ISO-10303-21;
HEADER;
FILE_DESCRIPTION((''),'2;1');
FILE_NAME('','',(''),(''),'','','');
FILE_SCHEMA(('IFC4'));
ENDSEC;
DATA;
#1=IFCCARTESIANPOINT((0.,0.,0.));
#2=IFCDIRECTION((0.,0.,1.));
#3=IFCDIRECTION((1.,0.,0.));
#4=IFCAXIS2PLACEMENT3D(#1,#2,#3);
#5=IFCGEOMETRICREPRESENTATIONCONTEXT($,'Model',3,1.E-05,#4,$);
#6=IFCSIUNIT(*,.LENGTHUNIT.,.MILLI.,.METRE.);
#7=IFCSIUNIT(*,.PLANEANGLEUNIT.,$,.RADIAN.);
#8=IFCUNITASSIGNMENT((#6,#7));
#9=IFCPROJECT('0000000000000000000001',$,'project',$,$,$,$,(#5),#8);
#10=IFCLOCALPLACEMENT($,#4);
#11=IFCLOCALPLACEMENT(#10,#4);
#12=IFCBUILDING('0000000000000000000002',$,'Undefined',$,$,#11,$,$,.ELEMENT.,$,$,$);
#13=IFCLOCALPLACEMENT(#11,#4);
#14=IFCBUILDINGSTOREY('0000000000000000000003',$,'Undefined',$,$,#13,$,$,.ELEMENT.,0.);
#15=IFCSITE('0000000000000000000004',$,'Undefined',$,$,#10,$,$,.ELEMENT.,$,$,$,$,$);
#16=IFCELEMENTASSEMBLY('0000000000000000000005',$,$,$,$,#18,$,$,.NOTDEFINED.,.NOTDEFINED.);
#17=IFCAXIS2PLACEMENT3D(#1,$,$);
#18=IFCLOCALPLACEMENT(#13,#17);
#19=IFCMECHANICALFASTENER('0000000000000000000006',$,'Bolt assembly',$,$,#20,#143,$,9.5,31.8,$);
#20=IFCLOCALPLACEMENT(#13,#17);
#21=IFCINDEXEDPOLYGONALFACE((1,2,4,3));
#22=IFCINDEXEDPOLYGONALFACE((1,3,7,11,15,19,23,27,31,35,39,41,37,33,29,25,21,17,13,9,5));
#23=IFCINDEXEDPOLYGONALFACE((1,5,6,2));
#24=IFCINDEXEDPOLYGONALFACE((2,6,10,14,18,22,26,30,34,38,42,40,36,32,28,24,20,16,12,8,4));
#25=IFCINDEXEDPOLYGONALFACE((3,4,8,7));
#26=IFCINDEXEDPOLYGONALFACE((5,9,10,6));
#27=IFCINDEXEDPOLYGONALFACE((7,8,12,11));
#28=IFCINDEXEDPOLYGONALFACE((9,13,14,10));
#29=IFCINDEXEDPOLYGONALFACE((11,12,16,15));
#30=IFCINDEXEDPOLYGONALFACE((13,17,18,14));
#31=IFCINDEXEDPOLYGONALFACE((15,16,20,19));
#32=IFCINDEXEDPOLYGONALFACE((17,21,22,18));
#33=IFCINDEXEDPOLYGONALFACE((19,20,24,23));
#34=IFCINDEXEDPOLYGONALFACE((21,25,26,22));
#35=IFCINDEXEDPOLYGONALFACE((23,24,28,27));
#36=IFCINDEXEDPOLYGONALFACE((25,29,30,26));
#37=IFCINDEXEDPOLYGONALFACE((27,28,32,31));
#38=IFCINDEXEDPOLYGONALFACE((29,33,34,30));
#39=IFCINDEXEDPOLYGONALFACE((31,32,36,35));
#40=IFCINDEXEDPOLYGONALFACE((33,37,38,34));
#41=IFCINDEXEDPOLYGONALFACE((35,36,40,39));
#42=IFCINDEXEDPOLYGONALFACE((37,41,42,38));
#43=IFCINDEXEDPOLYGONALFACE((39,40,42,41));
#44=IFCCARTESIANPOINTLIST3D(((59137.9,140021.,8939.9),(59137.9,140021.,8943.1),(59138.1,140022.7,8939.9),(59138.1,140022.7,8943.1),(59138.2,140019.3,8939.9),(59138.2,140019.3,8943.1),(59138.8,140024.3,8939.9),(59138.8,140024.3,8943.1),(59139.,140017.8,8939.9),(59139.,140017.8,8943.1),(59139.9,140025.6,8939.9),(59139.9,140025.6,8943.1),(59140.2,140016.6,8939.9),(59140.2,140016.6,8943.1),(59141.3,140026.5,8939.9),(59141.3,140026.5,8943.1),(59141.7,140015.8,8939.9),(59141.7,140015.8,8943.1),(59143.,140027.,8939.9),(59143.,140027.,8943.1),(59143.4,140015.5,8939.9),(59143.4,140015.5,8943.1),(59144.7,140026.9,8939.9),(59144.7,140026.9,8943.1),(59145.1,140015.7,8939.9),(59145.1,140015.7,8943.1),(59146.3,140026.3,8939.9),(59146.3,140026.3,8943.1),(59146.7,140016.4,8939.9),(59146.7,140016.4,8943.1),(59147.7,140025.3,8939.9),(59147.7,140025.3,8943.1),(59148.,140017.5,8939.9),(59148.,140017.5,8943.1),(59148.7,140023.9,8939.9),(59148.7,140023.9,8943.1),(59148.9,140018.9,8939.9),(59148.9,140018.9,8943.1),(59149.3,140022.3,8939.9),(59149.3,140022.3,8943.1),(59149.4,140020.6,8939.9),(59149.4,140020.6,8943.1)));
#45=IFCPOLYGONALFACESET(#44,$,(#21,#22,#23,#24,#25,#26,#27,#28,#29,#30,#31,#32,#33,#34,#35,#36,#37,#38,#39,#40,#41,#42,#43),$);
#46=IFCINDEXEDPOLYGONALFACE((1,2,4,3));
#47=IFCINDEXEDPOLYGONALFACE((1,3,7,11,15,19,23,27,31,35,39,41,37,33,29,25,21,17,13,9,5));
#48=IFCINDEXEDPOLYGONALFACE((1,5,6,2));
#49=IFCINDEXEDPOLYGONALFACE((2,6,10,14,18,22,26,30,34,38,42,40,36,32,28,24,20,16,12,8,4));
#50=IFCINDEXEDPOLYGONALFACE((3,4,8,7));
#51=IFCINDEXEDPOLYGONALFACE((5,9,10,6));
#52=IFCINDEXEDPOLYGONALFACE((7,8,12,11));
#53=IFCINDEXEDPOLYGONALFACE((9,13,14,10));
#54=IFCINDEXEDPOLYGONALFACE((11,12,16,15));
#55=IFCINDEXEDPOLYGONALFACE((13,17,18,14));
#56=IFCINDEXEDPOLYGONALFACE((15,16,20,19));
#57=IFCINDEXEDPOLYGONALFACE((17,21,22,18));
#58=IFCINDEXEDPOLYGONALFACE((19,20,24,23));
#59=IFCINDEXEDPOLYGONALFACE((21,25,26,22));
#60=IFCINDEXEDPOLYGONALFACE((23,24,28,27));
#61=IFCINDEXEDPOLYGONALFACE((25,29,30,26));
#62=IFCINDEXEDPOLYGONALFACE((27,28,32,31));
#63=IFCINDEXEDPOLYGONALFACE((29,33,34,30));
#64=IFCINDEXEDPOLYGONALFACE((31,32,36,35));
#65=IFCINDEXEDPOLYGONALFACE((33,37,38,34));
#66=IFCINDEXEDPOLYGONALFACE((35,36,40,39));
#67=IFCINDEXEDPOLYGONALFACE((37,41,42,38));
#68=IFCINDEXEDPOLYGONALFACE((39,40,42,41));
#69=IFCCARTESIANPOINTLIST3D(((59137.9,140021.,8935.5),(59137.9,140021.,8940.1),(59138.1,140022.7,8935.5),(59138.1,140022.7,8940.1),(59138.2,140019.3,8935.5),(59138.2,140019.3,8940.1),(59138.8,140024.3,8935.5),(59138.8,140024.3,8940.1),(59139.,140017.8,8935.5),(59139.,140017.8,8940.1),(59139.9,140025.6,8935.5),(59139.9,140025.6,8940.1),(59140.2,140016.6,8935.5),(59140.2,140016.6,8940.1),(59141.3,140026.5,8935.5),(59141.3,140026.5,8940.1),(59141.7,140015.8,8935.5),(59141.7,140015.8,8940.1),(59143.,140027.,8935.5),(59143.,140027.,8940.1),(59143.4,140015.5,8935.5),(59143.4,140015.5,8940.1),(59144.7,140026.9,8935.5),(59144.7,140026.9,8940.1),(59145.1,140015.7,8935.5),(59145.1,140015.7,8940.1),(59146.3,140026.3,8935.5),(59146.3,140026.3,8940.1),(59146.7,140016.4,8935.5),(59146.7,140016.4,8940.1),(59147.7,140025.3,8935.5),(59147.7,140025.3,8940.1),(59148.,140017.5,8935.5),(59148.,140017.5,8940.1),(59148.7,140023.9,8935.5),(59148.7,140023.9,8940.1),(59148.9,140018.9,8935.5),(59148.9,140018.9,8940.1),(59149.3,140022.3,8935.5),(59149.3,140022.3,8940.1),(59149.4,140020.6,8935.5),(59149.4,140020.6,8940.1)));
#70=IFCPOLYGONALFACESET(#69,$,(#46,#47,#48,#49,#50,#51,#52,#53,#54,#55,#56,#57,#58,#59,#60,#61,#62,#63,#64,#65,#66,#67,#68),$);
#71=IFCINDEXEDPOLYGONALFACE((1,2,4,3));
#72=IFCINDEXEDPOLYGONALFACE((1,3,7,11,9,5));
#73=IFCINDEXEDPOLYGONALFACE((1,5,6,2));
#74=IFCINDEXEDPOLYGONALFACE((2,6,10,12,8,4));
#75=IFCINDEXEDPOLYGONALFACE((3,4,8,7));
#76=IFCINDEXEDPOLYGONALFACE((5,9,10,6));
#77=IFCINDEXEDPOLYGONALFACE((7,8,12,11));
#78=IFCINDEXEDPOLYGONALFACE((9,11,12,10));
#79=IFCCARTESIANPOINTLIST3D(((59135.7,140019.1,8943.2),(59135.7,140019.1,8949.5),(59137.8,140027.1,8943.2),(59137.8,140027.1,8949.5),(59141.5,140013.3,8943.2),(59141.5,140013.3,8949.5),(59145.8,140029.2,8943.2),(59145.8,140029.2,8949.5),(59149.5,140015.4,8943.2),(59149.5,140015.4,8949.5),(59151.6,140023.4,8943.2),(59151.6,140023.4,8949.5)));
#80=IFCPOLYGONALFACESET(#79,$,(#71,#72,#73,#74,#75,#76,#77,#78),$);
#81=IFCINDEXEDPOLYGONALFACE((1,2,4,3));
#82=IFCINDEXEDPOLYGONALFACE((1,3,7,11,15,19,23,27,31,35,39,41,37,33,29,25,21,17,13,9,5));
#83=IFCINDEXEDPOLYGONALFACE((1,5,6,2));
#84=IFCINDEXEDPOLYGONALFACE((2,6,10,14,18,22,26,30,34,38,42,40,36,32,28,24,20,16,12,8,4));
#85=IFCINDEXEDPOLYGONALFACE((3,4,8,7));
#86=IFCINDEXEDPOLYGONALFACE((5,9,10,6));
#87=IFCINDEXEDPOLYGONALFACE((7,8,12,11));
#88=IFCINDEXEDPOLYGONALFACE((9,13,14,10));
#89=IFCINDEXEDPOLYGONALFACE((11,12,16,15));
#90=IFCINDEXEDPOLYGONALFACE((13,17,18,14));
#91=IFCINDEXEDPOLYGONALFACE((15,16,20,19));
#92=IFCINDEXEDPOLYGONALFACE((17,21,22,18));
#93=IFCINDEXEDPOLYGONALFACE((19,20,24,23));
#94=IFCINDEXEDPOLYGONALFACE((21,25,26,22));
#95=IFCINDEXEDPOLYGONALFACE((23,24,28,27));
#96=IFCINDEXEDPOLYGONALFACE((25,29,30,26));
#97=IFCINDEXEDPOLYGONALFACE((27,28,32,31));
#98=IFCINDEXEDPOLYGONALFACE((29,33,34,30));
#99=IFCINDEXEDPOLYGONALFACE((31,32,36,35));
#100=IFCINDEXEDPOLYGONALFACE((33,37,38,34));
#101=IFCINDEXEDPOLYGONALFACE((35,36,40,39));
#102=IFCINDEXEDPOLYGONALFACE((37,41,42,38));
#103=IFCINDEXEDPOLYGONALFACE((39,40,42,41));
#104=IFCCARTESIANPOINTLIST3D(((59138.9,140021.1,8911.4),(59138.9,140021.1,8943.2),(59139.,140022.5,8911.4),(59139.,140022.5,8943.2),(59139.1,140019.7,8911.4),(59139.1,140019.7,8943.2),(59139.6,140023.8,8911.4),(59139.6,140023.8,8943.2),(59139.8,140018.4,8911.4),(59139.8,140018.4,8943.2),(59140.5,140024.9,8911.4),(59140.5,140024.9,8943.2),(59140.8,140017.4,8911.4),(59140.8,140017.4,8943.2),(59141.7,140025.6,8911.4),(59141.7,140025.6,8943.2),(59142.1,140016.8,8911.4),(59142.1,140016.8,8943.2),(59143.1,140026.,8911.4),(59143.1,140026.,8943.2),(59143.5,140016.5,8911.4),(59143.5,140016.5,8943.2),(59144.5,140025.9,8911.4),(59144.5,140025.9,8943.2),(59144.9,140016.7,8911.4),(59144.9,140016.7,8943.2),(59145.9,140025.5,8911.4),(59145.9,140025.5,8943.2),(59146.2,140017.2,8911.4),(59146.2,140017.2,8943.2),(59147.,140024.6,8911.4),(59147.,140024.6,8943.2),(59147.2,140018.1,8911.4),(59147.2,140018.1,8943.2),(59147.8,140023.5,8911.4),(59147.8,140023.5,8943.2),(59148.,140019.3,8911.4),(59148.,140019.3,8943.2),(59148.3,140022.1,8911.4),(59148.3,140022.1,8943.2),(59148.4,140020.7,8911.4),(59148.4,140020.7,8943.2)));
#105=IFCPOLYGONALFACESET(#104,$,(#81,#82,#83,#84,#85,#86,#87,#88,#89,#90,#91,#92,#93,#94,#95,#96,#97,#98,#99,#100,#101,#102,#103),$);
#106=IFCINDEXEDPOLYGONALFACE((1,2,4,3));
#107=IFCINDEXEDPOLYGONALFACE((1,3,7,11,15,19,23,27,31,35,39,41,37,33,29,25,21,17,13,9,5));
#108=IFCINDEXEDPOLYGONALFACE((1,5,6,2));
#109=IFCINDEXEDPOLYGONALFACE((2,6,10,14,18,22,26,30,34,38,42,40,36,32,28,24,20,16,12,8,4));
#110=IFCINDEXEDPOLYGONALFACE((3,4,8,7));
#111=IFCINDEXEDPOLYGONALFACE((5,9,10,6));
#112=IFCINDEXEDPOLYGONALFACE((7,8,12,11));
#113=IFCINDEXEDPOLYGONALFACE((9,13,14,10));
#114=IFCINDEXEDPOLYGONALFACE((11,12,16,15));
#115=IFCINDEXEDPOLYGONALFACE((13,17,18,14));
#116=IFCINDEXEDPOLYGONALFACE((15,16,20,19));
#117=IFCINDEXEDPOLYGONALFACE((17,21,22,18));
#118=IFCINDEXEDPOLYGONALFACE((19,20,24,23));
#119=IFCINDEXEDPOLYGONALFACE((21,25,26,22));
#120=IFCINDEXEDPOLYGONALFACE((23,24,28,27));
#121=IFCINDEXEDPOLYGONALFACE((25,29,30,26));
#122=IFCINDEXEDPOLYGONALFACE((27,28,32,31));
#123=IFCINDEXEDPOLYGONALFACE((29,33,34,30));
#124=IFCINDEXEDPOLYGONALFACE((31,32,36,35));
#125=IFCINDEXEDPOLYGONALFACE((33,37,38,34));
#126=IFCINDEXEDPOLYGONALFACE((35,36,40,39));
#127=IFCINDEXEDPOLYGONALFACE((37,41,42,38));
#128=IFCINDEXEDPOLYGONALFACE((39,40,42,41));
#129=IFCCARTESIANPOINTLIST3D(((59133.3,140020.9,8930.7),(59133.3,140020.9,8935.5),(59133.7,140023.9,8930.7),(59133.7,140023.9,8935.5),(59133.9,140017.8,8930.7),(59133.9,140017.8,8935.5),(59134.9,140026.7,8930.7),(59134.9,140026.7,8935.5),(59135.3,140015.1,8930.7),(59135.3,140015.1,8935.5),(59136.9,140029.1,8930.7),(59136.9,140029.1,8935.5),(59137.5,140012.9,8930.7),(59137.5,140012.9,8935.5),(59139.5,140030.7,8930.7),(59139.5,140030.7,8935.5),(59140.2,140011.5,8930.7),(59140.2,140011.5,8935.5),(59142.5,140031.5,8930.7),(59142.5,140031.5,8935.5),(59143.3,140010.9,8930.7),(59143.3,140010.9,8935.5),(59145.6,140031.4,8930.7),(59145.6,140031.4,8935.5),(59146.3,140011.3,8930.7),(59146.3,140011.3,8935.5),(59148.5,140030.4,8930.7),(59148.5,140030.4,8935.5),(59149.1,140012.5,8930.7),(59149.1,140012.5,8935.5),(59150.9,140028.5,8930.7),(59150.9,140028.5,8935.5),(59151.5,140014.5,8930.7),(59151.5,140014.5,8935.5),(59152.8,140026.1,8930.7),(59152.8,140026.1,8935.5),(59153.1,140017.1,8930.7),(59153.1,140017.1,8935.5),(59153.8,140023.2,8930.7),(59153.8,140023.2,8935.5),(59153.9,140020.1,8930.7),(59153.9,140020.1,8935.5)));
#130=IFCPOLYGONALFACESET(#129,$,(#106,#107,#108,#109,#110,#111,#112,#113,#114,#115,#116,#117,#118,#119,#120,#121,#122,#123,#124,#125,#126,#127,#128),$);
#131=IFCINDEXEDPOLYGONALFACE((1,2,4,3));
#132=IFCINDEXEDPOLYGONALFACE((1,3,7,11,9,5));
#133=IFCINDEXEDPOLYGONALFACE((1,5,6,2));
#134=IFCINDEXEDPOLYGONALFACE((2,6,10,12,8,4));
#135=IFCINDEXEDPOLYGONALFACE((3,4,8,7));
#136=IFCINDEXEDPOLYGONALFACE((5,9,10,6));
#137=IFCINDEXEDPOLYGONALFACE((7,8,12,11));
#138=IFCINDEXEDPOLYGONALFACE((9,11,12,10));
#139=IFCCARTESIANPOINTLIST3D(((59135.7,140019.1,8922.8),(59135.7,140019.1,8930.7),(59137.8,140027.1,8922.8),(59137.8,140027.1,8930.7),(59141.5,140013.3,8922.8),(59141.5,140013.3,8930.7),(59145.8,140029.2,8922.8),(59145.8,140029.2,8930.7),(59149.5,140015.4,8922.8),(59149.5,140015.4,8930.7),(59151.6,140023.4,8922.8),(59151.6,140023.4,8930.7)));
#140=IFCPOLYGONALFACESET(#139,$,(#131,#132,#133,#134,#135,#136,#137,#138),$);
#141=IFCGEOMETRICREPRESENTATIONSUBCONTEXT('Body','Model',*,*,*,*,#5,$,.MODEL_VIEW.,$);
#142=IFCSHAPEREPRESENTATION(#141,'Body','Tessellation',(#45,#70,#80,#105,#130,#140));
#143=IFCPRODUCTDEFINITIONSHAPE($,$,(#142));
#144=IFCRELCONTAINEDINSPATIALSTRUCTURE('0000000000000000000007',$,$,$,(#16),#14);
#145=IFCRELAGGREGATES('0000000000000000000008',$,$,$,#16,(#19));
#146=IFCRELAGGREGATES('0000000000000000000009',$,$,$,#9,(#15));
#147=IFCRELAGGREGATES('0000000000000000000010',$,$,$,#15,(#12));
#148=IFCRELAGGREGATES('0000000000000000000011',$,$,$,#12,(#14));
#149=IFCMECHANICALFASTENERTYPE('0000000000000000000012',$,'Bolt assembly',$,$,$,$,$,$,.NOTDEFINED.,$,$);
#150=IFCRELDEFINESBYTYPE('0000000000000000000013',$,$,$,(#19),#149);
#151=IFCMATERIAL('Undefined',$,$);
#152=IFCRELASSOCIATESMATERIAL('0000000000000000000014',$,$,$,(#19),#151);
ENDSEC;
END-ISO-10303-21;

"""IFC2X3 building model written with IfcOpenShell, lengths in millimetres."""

from ifc_helpers import new_model, si_unit, frame, origin_with_axes, origin_2d_with_axis, place, context, subcontext, project, spatial, polyline, circle, outline, extrude, source, transform, mapped, material, type_object, element, aggregate, save


model = new_model("IFC2X3")

# Units and contexts
model_context = context("Model", 3, precision=1e-05, world=origin_with_axes())
body_context = subcontext(model_context, "Body", "Model", "MODEL_VIEW")
ifc_project = project(units=[si_unit("LENGTHUNIT", "METRE", prefix="MILLI"), si_unit("PLANEANGLEUNIT", "RADIAN")], contexts=[model_context])

# Site, building, storey
site_placement = place(None, origin_with_axes())
site = spatial("IfcSite", under=ifc_project, at=site_placement, Name="Undefined", CompositionType="ELEMENT")
building_placement = place(site_placement, origin_with_axes())
building = spatial("IfcBuilding", under=site, at=building_placement, Name="Undefined", CompositionType="ELEMENT")
storey_placement = place(building_placement, origin_with_axes())
storey = spatial("IfcBuildingStorey", under=building, at=storey_placement, Name="Undefined", CompositionType="ELEMENT", Elevation=0.0)

# Element assembly
assembly_1_placement = place(storey_placement, origin_with_axes())
assembly_1 = element("IfcElementAssembly", 1, at=assembly_1_placement, inside=storey, AssemblyPlace="NOTDEFINED", PredefinedType="NOTDEFINED")

# Mechanical fastener
ifc_material_1 = material(Name="Undefined")
mechanical_fastener_type = type_object("IfcMechanicalFastenerType", Name="Bolt assembly")
shared_shape_1 = source(origin_with_axes(), body_context, "Body", "SweptSolid", [
    extrude(circle(Radius=5.8, at=origin_2d_with_axis()), frame((0.0, -7.6, 0.0), z_axis=(0.0, 1.0, 0.0), x_axis=(1.0, 0.0, 0.0)), (0.0, 0.0, 1.0), 3.2),
    extrude(circle(Radius=5.8, at=origin_2d_with_axis()), frame((0.0, -4.6, 0.0), z_axis=(0.0, 1.0, 0.0), x_axis=(1.0, 0.0, 0.0)), (0.0, 0.0, 1.0), 4.6),
    extrude(outline(polyline([(7.1, -4.1), (7.1, 4.1), (0.0, 8.2), (-7.1, 4.1), (-7.1, -4.1), (0.0, -8.2), (7.1, -4.1)])), frame((0.0, -14.0, 0.0), z_axis=(0.0, 1.0, 0.0), x_axis=(1.0, 0.0, 0.0)), (0.0, 0.0, 1.0), 6.3),
    extrude(circle(Radius=4.8, at=origin_2d_with_axis()), frame((0.0, -7.7, 0.0), z_axis=(0.0, 1.0, 0.0), x_axis=(1.0, 0.0, 0.0)), (0.0, 0.0, 1.0), 31.8),
    extrude(circle(Radius=10.3, at=origin_2d_with_axis()), frame((0.0, 0.0, 0.0), z_axis=(0.0, 1.0, 0.0), x_axis=(1.0, 0.0, 0.0)), (0.0, 0.0, 1.0), 4.8),
    extrude(outline(polyline([(7.1, -4.1), (7.1, 4.1), (0.0, 8.2), (-7.1, 4.1), (-7.1, -4.1), (0.0, -8.2), (7.1, -4.1)])), frame((0.0, 4.8, 0.0), z_axis=(0.0, 1.0, 0.0), x_axis=(1.0, 0.0, 0.0)), (0.0, 0.0, 1.0), 7.9),
])
mechanical_fastener_1_placement = place(assembly_1_placement, frame((59143.6, 140021.3, 8935.5), z_axis=(-0.707107, 0.707107, 0.0), x_axis=(0.707107, 0.707107, 0.0)))
mechanical_fastener_1 = element("IfcMechanicalFastener", 2, at=mechanical_fastener_1_placement, type_object=mechanical_fastener_type, material=ifc_material_1, Name="Bolt assembly", NominalDiameter=9.5, NominalLength=31.8, context=body_context, shape_type="MappedRepresentation", body=[
    mapped(shared_shape_1, transform((0.0, 0.0, 0.0))),
])
aggregate(assembly_1, [mechanical_fastener_1])

save(model, "model.ifc")
